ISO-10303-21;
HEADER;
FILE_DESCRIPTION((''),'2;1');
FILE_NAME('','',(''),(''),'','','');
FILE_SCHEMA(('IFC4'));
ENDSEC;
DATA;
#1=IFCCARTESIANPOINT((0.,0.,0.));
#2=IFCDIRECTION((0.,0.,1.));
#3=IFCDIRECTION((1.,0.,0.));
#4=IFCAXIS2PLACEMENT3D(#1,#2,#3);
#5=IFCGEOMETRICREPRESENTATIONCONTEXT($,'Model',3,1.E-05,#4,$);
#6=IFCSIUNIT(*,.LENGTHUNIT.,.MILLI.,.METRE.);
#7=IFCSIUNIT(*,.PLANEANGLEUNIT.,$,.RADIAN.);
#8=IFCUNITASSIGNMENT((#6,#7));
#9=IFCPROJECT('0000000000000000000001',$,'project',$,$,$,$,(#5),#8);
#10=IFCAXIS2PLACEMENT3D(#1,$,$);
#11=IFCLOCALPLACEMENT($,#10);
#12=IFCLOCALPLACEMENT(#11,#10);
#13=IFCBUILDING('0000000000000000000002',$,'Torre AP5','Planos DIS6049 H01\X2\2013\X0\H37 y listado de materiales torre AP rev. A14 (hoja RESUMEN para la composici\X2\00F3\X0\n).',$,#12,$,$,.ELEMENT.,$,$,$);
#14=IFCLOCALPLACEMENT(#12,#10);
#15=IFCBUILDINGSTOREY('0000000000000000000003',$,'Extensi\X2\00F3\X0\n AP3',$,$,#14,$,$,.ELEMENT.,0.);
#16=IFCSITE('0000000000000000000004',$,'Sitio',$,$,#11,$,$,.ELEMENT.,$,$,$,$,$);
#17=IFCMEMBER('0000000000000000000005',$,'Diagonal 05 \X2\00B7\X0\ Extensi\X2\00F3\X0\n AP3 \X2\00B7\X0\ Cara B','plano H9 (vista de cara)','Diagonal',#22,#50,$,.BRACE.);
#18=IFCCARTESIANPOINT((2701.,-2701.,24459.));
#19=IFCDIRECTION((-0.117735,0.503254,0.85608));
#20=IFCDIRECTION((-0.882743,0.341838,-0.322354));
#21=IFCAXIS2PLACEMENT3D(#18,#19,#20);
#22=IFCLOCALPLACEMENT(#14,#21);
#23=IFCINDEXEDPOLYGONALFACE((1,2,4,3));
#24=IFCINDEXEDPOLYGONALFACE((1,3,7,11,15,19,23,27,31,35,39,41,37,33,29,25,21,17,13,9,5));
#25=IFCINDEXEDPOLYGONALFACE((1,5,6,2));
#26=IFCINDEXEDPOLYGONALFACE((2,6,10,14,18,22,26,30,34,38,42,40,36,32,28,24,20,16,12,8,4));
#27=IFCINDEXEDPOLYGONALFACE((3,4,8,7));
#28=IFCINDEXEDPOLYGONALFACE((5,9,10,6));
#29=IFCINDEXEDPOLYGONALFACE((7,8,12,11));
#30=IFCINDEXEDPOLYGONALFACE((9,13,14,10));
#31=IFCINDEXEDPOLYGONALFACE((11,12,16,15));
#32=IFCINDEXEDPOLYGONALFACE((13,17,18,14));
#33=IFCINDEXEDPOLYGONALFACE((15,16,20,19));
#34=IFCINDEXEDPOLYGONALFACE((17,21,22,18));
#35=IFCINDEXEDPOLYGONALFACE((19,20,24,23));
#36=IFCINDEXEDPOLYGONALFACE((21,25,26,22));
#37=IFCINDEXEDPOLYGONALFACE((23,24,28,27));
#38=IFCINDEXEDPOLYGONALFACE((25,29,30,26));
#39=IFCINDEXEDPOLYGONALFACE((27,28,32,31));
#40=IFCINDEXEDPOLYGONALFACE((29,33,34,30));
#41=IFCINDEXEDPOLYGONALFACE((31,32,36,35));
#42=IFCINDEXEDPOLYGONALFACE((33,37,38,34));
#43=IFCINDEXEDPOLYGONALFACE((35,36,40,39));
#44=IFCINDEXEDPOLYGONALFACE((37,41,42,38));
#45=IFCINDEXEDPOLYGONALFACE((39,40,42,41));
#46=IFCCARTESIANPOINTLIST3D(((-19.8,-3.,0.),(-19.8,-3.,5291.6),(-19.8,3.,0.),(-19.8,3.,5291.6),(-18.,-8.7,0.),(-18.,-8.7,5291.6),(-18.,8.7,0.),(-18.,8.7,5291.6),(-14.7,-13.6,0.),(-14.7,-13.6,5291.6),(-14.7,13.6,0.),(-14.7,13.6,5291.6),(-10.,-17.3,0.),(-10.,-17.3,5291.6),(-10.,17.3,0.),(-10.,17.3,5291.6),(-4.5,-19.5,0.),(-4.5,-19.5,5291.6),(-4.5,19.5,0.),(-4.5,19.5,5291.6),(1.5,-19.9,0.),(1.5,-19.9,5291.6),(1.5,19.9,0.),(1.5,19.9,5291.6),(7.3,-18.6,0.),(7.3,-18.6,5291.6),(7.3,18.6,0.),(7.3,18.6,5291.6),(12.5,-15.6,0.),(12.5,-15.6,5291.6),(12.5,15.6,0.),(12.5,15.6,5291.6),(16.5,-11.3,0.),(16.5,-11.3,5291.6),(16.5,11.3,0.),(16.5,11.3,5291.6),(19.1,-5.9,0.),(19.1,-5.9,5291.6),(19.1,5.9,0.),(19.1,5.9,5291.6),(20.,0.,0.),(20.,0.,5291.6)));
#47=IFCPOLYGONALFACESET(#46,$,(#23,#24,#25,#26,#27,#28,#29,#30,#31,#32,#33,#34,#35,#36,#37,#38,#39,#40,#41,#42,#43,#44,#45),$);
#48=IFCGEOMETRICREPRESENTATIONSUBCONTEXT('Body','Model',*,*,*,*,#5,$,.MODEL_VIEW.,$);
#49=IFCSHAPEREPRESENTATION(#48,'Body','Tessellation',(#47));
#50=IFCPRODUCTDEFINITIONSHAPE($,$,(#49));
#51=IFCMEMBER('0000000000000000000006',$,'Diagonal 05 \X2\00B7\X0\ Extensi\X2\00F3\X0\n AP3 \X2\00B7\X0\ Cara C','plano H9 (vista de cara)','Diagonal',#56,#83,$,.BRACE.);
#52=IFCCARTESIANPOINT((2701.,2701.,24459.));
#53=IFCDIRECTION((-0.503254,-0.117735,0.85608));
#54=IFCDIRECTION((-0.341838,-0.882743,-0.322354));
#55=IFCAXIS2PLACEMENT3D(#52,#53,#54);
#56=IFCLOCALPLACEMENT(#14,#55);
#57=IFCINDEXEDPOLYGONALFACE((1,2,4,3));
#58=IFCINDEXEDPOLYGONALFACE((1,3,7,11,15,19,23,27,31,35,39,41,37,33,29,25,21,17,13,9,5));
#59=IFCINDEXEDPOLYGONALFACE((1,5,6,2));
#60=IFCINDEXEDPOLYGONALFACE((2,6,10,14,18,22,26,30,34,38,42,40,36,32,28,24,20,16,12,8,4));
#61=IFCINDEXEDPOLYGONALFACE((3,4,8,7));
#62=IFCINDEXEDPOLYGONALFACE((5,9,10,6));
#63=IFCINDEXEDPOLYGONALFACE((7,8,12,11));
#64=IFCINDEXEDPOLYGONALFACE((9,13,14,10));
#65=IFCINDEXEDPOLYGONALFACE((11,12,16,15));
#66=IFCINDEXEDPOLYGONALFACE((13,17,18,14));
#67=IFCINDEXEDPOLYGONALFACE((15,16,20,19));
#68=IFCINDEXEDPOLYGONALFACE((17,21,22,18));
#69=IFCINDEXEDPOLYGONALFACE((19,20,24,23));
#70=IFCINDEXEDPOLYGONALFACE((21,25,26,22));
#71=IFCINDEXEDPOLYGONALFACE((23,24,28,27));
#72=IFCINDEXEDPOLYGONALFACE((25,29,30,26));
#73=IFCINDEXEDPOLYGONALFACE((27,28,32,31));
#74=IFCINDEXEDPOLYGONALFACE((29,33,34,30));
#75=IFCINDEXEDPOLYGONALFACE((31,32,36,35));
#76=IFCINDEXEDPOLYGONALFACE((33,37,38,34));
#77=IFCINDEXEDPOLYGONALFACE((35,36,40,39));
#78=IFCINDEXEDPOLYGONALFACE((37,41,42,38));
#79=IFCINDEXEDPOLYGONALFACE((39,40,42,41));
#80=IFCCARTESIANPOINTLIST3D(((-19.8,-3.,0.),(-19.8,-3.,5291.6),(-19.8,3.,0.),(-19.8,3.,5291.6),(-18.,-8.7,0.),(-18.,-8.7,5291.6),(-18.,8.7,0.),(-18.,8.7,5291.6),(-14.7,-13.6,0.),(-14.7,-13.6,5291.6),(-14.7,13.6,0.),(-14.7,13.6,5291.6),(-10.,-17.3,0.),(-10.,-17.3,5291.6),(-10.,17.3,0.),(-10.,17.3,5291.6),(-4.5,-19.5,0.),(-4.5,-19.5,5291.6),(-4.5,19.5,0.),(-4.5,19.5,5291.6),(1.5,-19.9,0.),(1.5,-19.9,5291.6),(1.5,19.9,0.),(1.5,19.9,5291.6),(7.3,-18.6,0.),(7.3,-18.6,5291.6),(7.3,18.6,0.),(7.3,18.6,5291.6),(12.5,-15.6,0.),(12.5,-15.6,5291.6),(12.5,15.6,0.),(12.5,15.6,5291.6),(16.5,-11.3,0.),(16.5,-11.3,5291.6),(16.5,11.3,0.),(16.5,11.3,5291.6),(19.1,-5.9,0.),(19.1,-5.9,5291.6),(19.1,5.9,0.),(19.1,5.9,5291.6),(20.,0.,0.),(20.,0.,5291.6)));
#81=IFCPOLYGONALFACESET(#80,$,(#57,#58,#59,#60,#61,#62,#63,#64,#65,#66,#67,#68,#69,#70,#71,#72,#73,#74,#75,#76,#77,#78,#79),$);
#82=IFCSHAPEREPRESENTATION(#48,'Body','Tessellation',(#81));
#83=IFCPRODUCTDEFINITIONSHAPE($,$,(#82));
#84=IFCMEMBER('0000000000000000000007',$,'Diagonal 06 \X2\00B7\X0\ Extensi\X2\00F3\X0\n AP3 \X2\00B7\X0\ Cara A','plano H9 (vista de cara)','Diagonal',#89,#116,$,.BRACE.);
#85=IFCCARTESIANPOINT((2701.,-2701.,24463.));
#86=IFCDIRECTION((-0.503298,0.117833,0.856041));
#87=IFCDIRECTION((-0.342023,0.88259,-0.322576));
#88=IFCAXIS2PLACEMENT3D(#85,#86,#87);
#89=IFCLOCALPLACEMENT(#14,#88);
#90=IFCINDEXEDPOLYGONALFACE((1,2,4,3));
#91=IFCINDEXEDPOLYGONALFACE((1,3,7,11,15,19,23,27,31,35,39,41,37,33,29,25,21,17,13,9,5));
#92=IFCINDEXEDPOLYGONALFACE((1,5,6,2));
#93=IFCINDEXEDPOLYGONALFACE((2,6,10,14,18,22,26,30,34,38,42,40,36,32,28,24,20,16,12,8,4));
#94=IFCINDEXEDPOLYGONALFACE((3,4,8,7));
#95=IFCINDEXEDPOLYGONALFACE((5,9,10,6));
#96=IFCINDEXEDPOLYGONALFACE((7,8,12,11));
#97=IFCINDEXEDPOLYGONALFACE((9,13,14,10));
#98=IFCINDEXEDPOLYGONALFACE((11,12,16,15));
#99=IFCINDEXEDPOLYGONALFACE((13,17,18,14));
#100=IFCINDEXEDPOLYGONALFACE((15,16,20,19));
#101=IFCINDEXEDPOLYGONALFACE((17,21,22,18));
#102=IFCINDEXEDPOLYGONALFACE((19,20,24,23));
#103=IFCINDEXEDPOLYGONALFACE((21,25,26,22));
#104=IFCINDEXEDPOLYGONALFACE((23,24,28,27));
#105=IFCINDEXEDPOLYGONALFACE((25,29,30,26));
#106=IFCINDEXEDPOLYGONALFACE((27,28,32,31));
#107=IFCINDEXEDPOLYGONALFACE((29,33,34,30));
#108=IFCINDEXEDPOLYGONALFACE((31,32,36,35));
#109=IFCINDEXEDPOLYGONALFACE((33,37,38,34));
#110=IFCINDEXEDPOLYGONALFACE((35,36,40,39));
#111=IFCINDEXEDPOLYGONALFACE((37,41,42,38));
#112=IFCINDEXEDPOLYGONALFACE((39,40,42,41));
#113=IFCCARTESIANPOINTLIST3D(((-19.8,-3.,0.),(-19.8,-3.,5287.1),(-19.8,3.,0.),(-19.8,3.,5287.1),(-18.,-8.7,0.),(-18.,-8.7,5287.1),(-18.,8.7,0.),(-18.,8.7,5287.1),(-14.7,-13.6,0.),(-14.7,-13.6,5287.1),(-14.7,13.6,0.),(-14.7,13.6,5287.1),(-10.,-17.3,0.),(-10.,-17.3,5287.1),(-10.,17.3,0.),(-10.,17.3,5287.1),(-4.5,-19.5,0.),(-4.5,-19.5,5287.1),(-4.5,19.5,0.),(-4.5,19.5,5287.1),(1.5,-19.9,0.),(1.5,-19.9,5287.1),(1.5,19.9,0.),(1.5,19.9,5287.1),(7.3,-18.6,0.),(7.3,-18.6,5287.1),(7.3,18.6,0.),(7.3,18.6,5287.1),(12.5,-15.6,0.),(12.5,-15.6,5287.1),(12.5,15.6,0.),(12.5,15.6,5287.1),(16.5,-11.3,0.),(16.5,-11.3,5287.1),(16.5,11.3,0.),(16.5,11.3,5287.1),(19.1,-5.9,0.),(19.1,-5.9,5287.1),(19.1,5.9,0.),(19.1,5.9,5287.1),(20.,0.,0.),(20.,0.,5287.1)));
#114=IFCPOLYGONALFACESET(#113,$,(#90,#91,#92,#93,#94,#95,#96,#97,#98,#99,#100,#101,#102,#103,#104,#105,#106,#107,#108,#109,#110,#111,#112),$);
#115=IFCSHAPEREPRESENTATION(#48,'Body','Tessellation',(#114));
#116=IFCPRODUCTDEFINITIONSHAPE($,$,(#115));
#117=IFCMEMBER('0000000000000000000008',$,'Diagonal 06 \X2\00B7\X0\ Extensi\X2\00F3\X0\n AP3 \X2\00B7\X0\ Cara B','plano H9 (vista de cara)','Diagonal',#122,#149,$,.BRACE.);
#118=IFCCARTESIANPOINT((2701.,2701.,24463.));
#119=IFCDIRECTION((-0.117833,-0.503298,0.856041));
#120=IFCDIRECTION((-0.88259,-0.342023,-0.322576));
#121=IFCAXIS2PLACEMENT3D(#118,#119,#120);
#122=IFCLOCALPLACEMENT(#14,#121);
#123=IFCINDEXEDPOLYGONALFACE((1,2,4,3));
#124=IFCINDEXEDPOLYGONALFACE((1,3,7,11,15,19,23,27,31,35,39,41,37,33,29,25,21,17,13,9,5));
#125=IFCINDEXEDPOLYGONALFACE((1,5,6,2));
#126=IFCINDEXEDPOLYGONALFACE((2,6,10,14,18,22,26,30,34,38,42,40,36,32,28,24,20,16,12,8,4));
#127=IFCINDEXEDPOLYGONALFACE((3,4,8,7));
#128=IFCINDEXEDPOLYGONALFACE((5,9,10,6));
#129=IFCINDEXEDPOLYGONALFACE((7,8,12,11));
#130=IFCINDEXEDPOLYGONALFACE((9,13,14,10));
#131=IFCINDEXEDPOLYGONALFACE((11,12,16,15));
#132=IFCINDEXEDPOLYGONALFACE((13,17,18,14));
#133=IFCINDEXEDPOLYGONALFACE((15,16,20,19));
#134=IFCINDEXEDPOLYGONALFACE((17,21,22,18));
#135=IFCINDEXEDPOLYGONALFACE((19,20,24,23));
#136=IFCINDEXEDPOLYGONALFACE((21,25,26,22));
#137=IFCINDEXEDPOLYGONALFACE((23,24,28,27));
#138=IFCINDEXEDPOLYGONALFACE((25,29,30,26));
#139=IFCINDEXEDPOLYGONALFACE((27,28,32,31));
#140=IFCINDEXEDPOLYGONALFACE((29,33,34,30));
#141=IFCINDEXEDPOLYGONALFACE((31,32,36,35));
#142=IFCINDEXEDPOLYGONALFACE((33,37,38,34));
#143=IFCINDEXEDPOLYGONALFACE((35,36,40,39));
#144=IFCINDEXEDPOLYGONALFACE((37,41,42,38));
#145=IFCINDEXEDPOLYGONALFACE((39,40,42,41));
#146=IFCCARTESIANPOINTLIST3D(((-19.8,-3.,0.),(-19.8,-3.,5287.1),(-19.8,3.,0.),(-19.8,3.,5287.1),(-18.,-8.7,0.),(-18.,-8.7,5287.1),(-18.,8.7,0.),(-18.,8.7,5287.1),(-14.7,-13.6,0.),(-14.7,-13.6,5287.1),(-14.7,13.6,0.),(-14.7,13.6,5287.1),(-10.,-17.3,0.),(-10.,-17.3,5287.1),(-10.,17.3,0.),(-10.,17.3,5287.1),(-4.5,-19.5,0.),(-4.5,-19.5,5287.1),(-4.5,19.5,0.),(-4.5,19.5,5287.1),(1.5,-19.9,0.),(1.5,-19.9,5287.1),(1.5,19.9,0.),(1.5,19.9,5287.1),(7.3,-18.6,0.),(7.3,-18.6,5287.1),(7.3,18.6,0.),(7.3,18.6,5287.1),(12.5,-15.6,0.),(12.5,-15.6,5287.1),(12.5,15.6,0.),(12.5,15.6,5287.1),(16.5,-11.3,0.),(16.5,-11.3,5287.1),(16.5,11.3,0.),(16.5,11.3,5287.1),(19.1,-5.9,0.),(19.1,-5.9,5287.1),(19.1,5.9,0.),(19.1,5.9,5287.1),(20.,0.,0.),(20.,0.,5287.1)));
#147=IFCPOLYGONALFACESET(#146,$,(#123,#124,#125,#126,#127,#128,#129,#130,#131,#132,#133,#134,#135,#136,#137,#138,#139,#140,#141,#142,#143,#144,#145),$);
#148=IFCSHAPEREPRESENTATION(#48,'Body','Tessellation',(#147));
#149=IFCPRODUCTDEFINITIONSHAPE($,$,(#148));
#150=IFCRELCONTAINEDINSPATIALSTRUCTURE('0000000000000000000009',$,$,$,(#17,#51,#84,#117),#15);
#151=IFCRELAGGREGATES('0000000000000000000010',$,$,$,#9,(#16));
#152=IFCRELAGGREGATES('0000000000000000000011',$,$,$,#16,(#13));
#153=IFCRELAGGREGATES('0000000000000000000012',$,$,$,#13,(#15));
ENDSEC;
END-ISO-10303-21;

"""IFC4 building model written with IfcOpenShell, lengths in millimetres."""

from ifc_helpers import new_model, si_unit, frame, origin, origin_with_axes, place, context, subcontext, project, spatial, circle, extrude, element, save


model = new_model("IFC4")

# Units and contexts
model_context = context("Model", 3, precision=1e-05, world=origin_with_axes())
body_context = subcontext(model_context, "Body", "Model", "MODEL_VIEW")
ifc_project = project(units=[si_unit("LENGTHUNIT", "METRE", prefix="MILLI"), si_unit("PLANEANGLEUNIT", "RADIAN")], contexts=[model_context])

# Site, building, storey
site_placement = place(None, origin())
site = spatial("IfcSite", under=ifc_project, at=site_placement, Name="Sitio", CompositionType="ELEMENT")
building_placement = place(site_placement, origin())
building = spatial("IfcBuilding", under=site, at=building_placement, Name="Torre AP5", Description="Planos DIS6049 H01–H37 y listado de materiales torre AP rev. A14 (hoja RESUMEN para la composición).", CompositionType="ELEMENT")
storey_placement = place(building_placement, origin())
storey = spatial("IfcBuildingStorey", under=building, at=storey_placement, Name="Extensión AP3", CompositionType="ELEMENT", Elevation=0.0)

# Members
for number, where, z_axis, x_axis, name in (
    (1, (2701.0, -2701.0, 24459.0), (-0.117735, 0.503254, 0.85608), (-0.882743, 0.341838, -0.322354), "Diagonal 05 · Extensión AP3 · Cara B"),
    (2, (2701.0, 2701.0, 24459.0), (-0.503254, -0.117735, 0.85608), (-0.341838, -0.882743, -0.322354), "Diagonal 05 · Extensión AP3 · Cara C"),
):
    element("IfcMember", number, at=place(storey_placement, frame(where, z_axis=z_axis, x_axis=x_axis)), inside=storey, Name=name, Description="plano H9 (vista de cara)", ObjectType="Diagonal", PredefinedType="BRACE", context=body_context, shape_type="SweptSolid", body=[
        extrude(circle(Radius=20.0), None, (0.0, 0.0, 1.0), 5291.6),
    ])
for number, where, z_axis, x_axis, name in (
    (3, (2701.0, -2701.0, 24463.0), (-0.503298, 0.117833, 0.856041), (-0.342023, 0.88259, -0.322576), "Diagonal 06 · Extensión AP3 · Cara A"),
    (4, (2701.0, 2701.0, 24463.0), (-0.117833, -0.503298, 0.856041), (-0.88259, -0.342023, -0.322576), "Diagonal 06 · Extensión AP3 · Cara B"),
):
    element("IfcMember", number, at=place(storey_placement, frame(where, z_axis=z_axis, x_axis=x_axis)), inside=storey, Name=name, Description="plano H9 (vista de cara)", ObjectType="Diagonal", PredefinedType="BRACE", context=body_context, shape_type="SweptSolid", body=[
        extrude(circle(Radius=20.0), None, (0.0, 0.0, 1.0), 5287.1),
    ])

save(model, "model.ifc")
